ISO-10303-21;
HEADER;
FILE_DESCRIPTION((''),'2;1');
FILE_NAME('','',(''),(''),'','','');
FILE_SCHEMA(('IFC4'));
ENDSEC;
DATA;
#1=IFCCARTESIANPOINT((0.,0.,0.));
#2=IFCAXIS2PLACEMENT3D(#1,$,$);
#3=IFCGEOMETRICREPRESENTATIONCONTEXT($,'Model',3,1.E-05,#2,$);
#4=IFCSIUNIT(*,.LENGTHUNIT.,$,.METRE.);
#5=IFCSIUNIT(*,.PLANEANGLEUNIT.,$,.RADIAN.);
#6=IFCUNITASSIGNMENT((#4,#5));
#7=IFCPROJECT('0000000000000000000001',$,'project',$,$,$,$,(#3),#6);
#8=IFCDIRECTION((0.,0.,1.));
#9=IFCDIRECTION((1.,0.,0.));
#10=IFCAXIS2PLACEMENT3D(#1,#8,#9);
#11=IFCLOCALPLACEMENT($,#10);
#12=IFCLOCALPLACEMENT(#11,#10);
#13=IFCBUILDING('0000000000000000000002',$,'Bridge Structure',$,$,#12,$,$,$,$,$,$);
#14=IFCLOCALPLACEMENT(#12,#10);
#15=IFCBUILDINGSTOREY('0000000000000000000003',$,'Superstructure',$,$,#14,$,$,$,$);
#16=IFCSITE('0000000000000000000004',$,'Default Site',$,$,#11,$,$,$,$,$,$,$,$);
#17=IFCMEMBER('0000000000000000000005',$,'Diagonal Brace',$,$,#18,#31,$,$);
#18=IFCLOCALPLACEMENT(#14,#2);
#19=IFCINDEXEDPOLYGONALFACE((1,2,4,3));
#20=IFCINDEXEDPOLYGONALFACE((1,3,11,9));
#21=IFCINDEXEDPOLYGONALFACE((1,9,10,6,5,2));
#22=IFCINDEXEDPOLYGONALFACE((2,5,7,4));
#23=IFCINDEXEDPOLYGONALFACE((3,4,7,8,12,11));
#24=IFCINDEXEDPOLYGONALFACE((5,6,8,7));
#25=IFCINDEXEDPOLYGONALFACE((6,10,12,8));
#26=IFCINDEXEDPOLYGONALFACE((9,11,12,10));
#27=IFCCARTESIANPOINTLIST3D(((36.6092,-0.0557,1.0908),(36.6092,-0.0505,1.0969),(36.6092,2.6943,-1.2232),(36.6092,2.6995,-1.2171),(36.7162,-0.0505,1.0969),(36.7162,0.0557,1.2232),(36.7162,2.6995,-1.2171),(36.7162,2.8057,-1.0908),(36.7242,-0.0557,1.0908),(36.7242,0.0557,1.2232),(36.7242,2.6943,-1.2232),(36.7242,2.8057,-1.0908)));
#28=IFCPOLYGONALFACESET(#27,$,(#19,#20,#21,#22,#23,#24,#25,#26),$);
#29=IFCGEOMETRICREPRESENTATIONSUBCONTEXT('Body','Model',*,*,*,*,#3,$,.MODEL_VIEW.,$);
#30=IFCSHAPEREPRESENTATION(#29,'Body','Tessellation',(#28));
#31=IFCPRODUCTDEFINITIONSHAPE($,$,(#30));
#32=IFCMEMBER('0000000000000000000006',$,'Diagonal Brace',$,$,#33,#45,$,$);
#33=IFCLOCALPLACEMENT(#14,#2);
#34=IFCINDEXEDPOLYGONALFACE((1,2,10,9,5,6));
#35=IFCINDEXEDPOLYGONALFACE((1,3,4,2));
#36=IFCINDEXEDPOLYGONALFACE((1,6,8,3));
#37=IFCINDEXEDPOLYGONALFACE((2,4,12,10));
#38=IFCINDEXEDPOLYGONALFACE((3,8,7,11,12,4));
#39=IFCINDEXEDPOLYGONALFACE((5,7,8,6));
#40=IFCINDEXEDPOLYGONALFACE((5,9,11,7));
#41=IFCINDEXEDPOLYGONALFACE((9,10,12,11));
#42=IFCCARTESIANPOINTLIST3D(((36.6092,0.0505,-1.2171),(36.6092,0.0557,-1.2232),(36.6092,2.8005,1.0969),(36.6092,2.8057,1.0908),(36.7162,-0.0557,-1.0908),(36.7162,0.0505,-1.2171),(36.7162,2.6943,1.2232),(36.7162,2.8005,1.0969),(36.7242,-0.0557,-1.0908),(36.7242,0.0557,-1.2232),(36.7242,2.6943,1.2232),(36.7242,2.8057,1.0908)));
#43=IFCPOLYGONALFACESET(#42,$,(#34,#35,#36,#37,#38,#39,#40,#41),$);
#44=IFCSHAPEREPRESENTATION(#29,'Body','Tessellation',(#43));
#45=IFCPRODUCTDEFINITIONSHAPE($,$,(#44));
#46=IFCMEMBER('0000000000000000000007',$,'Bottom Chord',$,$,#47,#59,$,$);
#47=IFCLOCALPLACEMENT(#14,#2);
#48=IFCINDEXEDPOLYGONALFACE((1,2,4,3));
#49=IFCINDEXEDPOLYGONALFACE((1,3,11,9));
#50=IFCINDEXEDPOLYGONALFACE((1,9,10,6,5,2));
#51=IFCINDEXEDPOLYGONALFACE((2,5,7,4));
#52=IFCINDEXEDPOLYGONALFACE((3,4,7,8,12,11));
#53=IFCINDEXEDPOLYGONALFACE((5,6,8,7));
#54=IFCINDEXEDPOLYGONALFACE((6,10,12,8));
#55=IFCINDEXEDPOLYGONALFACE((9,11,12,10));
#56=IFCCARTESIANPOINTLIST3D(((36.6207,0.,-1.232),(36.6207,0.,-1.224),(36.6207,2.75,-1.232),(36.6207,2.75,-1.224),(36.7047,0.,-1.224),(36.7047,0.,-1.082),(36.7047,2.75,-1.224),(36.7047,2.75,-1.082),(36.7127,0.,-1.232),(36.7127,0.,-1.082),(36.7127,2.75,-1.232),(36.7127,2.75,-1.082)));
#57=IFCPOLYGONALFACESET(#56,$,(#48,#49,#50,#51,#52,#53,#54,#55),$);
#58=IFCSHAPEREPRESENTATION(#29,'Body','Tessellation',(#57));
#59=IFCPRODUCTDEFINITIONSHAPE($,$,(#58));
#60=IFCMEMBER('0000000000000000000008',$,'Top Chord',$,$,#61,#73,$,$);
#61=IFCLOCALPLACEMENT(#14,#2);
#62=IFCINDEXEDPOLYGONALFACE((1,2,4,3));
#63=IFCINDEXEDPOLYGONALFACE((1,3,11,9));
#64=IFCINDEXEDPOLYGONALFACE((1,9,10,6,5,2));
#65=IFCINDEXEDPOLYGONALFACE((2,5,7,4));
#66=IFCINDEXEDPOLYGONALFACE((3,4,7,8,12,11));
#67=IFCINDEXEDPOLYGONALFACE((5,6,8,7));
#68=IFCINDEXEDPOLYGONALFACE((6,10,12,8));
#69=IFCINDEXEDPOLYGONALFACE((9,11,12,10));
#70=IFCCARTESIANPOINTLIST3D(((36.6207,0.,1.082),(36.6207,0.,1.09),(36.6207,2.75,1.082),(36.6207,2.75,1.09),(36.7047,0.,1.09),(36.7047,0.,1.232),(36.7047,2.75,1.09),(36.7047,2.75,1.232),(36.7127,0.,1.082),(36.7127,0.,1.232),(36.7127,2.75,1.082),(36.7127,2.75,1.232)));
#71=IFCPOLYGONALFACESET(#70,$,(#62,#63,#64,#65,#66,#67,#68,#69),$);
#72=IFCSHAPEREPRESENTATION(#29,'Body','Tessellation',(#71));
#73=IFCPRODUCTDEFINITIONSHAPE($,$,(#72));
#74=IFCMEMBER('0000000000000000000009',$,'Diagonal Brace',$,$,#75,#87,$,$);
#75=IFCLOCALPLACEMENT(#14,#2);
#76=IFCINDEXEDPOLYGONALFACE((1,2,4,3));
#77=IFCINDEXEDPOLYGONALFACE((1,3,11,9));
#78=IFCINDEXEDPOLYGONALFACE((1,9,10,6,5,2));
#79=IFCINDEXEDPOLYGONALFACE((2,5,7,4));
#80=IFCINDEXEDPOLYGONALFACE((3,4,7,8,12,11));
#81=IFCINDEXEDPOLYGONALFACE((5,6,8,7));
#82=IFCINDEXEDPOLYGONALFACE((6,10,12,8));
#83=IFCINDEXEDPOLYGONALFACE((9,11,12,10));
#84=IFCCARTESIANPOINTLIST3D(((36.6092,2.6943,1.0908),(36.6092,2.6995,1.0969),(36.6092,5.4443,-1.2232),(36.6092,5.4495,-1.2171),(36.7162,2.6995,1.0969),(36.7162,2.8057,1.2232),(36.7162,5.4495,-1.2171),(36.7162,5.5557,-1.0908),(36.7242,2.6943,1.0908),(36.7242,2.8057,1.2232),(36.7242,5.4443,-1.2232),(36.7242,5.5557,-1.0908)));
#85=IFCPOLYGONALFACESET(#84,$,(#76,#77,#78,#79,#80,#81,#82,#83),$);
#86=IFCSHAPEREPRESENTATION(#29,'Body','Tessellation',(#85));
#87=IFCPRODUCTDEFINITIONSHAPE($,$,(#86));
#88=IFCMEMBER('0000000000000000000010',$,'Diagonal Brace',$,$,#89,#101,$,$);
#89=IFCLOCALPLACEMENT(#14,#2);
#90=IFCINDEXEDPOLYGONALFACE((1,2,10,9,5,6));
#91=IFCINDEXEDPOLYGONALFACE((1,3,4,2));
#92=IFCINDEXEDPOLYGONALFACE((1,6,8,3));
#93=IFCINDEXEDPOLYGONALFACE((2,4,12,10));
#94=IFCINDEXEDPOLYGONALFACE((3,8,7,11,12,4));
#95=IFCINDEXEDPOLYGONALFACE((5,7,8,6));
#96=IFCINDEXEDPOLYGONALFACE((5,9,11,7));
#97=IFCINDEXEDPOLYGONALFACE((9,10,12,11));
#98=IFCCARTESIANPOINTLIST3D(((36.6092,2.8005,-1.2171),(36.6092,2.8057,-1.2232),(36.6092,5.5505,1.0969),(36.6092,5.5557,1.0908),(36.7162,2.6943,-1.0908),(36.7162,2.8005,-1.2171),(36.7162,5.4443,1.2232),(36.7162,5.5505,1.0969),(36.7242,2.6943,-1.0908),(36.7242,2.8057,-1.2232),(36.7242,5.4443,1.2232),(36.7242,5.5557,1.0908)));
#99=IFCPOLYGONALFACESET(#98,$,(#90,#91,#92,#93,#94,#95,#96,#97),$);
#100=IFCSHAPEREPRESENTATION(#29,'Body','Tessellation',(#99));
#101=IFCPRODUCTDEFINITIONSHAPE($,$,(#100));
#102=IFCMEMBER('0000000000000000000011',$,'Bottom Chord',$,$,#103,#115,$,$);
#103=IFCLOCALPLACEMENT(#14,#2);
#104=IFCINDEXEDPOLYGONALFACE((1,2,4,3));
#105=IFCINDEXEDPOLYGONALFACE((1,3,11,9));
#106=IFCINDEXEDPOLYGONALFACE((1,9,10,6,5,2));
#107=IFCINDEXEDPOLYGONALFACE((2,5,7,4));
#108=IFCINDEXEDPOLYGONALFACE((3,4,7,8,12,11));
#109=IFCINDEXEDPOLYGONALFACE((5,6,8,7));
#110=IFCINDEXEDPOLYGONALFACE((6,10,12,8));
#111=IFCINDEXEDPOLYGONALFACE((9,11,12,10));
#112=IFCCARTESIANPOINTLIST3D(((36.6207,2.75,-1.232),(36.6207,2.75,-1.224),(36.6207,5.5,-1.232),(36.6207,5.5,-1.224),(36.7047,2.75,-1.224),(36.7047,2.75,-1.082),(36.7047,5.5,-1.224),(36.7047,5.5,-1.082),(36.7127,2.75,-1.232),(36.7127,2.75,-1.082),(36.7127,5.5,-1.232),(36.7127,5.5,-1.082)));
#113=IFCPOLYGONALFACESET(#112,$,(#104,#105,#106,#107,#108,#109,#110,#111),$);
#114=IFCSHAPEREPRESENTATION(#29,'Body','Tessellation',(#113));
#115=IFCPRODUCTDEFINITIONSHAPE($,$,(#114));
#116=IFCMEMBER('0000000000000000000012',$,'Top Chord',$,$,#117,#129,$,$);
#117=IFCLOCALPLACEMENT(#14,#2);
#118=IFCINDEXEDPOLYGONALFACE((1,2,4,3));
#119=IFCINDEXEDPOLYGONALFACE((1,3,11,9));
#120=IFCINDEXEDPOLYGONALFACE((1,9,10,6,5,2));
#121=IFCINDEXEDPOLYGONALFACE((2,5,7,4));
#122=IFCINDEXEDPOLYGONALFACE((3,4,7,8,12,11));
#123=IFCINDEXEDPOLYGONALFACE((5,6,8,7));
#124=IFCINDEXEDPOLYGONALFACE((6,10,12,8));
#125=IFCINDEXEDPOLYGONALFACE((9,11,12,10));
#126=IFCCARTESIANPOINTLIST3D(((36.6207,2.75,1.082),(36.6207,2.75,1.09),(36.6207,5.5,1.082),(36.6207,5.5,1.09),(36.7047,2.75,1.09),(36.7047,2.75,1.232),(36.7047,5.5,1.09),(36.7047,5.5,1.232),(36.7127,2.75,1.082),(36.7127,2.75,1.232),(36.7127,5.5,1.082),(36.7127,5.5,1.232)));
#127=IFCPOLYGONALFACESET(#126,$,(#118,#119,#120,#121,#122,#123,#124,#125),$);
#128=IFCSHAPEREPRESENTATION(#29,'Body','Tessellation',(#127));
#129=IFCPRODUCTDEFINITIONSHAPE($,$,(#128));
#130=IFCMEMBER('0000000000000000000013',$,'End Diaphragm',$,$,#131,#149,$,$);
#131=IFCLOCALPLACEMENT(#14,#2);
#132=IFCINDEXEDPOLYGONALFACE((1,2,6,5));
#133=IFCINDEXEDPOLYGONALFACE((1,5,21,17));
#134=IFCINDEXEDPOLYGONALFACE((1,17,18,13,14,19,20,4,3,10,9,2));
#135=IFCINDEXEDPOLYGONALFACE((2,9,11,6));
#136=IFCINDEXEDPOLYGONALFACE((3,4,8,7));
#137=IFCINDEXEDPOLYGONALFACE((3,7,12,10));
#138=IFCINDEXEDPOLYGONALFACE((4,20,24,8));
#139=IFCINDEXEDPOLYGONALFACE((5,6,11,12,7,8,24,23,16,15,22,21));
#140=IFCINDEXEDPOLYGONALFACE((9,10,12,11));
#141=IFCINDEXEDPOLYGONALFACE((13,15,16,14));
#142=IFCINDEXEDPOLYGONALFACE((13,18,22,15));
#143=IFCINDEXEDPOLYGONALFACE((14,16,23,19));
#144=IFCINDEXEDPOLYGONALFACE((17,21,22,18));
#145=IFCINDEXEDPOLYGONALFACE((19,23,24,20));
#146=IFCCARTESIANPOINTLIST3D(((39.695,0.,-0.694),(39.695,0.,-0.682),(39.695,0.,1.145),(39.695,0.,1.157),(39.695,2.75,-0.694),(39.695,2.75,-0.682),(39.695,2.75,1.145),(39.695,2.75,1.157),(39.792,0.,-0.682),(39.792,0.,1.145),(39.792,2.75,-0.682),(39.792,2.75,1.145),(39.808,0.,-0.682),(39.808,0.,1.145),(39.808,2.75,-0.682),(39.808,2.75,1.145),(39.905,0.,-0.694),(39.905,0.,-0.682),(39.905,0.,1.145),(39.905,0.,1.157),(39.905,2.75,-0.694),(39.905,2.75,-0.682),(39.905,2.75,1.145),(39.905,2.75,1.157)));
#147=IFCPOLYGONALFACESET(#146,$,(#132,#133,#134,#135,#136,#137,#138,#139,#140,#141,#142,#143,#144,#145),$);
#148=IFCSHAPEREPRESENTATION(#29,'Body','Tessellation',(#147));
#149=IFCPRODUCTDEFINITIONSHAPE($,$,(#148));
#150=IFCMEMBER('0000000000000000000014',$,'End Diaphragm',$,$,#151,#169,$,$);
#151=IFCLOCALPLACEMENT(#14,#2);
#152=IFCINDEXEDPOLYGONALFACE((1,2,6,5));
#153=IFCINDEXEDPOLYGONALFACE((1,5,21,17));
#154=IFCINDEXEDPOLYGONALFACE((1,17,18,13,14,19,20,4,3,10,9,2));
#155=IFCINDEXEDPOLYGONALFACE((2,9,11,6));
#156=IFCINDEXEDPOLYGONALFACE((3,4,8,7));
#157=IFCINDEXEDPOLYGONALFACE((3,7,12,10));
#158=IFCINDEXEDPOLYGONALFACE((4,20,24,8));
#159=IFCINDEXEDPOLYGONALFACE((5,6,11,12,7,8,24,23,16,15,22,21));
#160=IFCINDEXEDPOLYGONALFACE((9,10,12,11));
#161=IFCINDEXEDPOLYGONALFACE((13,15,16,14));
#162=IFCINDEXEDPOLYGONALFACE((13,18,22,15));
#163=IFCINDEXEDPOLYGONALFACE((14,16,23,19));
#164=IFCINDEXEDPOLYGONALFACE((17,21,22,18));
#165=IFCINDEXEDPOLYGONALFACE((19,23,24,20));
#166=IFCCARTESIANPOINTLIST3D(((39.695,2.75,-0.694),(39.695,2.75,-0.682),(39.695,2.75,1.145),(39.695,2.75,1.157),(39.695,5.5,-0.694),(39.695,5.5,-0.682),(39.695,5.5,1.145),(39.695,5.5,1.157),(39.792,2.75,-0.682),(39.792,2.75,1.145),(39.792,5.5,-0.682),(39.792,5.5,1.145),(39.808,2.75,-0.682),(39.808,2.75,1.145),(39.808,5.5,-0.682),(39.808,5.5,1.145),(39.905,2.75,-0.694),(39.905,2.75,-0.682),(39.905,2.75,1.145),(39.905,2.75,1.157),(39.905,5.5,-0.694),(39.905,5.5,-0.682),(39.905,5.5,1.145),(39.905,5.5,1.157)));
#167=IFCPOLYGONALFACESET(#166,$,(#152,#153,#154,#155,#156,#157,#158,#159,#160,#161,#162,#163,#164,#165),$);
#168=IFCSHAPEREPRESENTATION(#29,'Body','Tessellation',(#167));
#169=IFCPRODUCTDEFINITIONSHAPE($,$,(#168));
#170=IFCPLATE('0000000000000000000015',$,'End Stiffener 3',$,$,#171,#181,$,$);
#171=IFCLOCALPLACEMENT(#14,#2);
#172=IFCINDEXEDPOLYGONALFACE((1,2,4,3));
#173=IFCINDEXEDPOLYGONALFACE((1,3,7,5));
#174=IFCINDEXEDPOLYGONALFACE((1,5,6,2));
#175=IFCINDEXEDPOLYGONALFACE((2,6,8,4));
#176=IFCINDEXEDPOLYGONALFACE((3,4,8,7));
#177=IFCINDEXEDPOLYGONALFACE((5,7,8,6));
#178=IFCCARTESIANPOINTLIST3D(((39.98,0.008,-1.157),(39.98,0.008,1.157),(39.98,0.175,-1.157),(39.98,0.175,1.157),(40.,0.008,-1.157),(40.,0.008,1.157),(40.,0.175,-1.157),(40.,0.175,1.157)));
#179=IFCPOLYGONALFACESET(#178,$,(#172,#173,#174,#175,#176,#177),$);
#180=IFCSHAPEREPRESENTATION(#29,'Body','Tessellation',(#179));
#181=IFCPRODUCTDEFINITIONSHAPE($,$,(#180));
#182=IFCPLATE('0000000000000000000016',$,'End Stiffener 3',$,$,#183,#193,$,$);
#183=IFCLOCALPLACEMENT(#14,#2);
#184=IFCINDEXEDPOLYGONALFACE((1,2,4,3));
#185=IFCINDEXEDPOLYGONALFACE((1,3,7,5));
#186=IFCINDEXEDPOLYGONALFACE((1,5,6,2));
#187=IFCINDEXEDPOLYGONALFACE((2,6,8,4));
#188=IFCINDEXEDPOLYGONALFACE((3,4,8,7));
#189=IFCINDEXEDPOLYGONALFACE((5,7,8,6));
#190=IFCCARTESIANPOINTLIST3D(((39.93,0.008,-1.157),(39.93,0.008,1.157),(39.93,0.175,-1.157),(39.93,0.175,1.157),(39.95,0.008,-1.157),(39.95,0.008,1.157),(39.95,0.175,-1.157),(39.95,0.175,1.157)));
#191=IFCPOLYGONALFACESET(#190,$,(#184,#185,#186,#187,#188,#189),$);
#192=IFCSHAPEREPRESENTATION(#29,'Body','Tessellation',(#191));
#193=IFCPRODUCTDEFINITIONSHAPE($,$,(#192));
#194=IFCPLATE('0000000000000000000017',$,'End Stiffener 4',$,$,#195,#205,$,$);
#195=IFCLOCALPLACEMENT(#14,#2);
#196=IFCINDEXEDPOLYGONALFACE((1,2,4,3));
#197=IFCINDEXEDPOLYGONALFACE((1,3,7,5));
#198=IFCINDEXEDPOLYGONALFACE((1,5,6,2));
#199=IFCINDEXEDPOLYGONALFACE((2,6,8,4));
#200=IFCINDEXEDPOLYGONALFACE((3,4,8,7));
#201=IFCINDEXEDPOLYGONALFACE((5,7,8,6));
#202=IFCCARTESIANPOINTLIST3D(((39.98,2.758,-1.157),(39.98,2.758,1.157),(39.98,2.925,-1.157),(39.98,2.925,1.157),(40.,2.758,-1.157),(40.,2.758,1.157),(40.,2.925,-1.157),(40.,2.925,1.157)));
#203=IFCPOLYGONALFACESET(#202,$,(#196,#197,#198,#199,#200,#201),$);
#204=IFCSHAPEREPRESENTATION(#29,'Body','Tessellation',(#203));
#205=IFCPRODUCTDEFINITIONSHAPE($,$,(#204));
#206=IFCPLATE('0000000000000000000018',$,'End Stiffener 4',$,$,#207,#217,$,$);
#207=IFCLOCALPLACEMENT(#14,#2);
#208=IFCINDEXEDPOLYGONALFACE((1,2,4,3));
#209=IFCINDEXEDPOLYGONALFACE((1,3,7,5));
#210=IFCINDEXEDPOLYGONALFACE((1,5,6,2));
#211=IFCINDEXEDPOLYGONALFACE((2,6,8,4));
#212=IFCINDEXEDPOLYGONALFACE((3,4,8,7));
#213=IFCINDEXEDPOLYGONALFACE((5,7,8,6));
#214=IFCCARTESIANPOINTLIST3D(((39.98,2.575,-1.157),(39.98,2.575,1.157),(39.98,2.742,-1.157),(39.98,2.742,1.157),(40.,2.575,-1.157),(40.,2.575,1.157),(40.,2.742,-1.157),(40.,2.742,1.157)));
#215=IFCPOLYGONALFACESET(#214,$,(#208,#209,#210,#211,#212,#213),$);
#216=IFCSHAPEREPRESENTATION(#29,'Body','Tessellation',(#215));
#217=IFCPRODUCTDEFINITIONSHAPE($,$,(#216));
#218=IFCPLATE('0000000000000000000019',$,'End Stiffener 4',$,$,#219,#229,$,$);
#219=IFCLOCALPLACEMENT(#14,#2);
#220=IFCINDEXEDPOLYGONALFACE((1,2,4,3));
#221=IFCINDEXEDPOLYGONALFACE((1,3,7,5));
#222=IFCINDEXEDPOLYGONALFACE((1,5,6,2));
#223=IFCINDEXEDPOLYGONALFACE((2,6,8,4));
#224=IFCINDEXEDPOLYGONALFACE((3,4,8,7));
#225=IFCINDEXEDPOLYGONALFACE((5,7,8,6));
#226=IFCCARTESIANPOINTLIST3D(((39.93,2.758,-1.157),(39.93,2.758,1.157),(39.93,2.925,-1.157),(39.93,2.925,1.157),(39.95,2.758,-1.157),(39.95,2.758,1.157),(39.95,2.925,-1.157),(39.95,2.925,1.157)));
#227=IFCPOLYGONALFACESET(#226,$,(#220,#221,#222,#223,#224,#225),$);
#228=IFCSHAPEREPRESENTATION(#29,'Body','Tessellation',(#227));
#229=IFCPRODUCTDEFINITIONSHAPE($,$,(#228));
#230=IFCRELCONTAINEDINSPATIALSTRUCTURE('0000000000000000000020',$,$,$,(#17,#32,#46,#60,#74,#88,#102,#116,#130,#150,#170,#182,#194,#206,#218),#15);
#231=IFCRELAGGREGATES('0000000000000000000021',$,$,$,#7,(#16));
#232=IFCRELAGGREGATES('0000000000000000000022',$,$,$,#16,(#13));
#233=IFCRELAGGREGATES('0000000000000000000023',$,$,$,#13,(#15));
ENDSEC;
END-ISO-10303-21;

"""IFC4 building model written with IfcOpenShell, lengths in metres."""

from ifc_helpers import new_model, si_unit, frame, origin, origin_with_axes, origin_2d_with_axis, place, context, subcontext, project, spatial, rectangle, i_section, l_section, extrude, element, save


model = new_model("IFC4")

# Units and contexts
model_context = context("Model", 3, precision=1e-05, world=origin())
body_context = subcontext(model_context, "Body", "Model", "MODEL_VIEW")
ifc_project = project(units=[si_unit("LENGTHUNIT", "METRE"), si_unit("PLANEANGLEUNIT", "RADIAN")], contexts=[model_context])

# Site, building, storey
site_placement = place(None, origin_with_axes())
site = spatial("IfcSite", under=ifc_project, at=site_placement, Name="Default Site")
building_placement = place(site_placement, origin_with_axes())
building = spatial("IfcBuilding", under=site, at=building_placement, Name="Bridge Structure")
storey_placement = place(building_placement, origin_with_axes())
storey = spatial("IfcBuildingStorey", under=building, at=storey_placement, Name="Superstructure")

# Members
for number, where, z_axis, x_axis, name in (
    (1, (36.6667, 0.0, 1.157), (0.0, 0.765156, -0.643844), (-1.0, 0.0, 0.0), "Diagonal Brace"),
    (2, (36.6667, 0.0, -1.157), (0.0, 0.765156, 0.643844), (-1.0, 0.0, 0.0), "Diagonal Brace"),
):
    element("IfcMember", number, at=place(storey_placement, frame(where, z_axis=z_axis, x_axis=x_axis)), inside=storey, Name=name, context=body_context, shape_type="SweptSolid", body=[
        extrude(l_section(Depth=0.173, Width=0.115, Thickness=0.008, at=origin_2d_with_axis()), origin_with_axes(), (0.0, 0.0, 1.0), 3.594),
    ])
for number, where, z_axis, x_axis, name in (
    (3, (36.6667, 0.0, -1.157), (0.0, 1.0, 0.0), (-1.0, 0.0, 0.0), "Bottom Chord"),
    (4, (36.6667, 0.0, 1.157), (0.0, 1.0, 0.0), (-1.0, 0.0, 0.0), "Top Chord"),
):
    element("IfcMember", number, at=place(storey_placement, frame(where, z_axis=z_axis, x_axis=x_axis)), inside=storey, Name=name, context=body_context, shape_type="SweptSolid", body=[
        extrude(l_section(Depth=0.15, Width=0.092, Thickness=0.008, at=origin_2d_with_axis()), origin_with_axes(), (0.0, 0.0, 1.0), 2.75),
    ])
for number, where, z_axis, x_axis, name in (
    (5, (36.6667, 2.75, 1.157), (0.0, 0.765156, -0.643844), (-1.0, 0.0, 0.0), "Diagonal Brace"),
    (6, (36.6667, 2.75, -1.157), (0.0, 0.765156, 0.643844), (-1.0, 0.0, 0.0), "Diagonal Brace"),
):
    element("IfcMember", number, at=place(storey_placement, frame(where, z_axis=z_axis, x_axis=x_axis)), inside=storey, Name=name, context=body_context, shape_type="SweptSolid", body=[
        extrude(l_section(Depth=0.173, Width=0.115, Thickness=0.008, at=origin_2d_with_axis()), origin_with_axes(), (0.0, 0.0, 1.0), 3.594),
    ])
for number, where, z_axis, x_axis, name in (
    (7, (36.6667, 2.75, -1.157), (0.0, 1.0, 0.0), (-1.0, 0.0, 0.0), "Bottom Chord"),
    (8, (36.6667, 2.75, 1.157), (0.0, 1.0, 0.0), (-1.0, 0.0, 0.0), "Top Chord"),
):
    element("IfcMember", number, at=place(storey_placement, frame(where, z_axis=z_axis, x_axis=x_axis)), inside=storey, Name=name, context=body_context, shape_type="SweptSolid", body=[
        extrude(l_section(Depth=0.15, Width=0.092, Thickness=0.008, at=origin_2d_with_axis()), origin_with_axes(), (0.0, 0.0, 1.0), 2.75),
    ])
for number, where, z_axis, x_axis, name in (
    (9, (39.8, 0.0, 0.2315), (0.0, 1.0, 0.0), (-1.0, 0.0, 0.0), "End Diaphragm"),
    (10, (39.8, 2.75, 0.2315), (0.0, 1.0, 0.0), (-1.0, 0.0, 0.0), "End Diaphragm"),
):
    element("IfcMember", number, at=place(storey_placement, frame(where, z_axis=z_axis, x_axis=x_axis)), inside=storey, Name=name, context=body_context, shape_type="SweptSolid", body=[
        extrude(i_section(OverallWidth=0.21, OverallDepth=1.851, WebThickness=0.016, FlangeThickness=0.012, at=origin_2d_with_axis()), origin_with_axes(), (0.0, 0.0, 1.0), 2.75),
    ])

# Plates
for number, where, z_axis, x_axis, name in (
    (11, (39.99, 0.0915, -1.157), (0.0, 0.0, 1.0), (1.0, 0.0, 0.0), "End Stiffener 3"),
    (12, (39.94, 0.0915, -1.157), (0.0, 0.0, 1.0), (1.0, 0.0, 0.0), "End Stiffener 3"),
    (13, (39.99, 2.8415, -1.157), (0.0, 0.0, 1.0), (1.0, 0.0, 0.0), "End Stiffener 4"),
    (14, (39.99, 2.6585, -1.157), (0.0, 0.0, 1.0), (1.0, 0.0, 0.0), "End Stiffener 4"),
    (15, (39.94, 2.8415, -1.157), (0.0, 0.0, 1.0), (1.0, 0.0, 0.0), "End Stiffener 4"),
):
    element("IfcPlate", number, at=place(storey_placement, frame(where, z_axis=z_axis, x_axis=x_axis)), inside=storey, Name=name, context=body_context, shape_type="SweptSolid", body=[
        extrude(rectangle(XDim=0.02, YDim=0.167, at=origin_2d_with_axis()), origin_with_axes(), (0.0, 0.0, 1.0), 2.314),
    ])

save(model, "model.ifc")
